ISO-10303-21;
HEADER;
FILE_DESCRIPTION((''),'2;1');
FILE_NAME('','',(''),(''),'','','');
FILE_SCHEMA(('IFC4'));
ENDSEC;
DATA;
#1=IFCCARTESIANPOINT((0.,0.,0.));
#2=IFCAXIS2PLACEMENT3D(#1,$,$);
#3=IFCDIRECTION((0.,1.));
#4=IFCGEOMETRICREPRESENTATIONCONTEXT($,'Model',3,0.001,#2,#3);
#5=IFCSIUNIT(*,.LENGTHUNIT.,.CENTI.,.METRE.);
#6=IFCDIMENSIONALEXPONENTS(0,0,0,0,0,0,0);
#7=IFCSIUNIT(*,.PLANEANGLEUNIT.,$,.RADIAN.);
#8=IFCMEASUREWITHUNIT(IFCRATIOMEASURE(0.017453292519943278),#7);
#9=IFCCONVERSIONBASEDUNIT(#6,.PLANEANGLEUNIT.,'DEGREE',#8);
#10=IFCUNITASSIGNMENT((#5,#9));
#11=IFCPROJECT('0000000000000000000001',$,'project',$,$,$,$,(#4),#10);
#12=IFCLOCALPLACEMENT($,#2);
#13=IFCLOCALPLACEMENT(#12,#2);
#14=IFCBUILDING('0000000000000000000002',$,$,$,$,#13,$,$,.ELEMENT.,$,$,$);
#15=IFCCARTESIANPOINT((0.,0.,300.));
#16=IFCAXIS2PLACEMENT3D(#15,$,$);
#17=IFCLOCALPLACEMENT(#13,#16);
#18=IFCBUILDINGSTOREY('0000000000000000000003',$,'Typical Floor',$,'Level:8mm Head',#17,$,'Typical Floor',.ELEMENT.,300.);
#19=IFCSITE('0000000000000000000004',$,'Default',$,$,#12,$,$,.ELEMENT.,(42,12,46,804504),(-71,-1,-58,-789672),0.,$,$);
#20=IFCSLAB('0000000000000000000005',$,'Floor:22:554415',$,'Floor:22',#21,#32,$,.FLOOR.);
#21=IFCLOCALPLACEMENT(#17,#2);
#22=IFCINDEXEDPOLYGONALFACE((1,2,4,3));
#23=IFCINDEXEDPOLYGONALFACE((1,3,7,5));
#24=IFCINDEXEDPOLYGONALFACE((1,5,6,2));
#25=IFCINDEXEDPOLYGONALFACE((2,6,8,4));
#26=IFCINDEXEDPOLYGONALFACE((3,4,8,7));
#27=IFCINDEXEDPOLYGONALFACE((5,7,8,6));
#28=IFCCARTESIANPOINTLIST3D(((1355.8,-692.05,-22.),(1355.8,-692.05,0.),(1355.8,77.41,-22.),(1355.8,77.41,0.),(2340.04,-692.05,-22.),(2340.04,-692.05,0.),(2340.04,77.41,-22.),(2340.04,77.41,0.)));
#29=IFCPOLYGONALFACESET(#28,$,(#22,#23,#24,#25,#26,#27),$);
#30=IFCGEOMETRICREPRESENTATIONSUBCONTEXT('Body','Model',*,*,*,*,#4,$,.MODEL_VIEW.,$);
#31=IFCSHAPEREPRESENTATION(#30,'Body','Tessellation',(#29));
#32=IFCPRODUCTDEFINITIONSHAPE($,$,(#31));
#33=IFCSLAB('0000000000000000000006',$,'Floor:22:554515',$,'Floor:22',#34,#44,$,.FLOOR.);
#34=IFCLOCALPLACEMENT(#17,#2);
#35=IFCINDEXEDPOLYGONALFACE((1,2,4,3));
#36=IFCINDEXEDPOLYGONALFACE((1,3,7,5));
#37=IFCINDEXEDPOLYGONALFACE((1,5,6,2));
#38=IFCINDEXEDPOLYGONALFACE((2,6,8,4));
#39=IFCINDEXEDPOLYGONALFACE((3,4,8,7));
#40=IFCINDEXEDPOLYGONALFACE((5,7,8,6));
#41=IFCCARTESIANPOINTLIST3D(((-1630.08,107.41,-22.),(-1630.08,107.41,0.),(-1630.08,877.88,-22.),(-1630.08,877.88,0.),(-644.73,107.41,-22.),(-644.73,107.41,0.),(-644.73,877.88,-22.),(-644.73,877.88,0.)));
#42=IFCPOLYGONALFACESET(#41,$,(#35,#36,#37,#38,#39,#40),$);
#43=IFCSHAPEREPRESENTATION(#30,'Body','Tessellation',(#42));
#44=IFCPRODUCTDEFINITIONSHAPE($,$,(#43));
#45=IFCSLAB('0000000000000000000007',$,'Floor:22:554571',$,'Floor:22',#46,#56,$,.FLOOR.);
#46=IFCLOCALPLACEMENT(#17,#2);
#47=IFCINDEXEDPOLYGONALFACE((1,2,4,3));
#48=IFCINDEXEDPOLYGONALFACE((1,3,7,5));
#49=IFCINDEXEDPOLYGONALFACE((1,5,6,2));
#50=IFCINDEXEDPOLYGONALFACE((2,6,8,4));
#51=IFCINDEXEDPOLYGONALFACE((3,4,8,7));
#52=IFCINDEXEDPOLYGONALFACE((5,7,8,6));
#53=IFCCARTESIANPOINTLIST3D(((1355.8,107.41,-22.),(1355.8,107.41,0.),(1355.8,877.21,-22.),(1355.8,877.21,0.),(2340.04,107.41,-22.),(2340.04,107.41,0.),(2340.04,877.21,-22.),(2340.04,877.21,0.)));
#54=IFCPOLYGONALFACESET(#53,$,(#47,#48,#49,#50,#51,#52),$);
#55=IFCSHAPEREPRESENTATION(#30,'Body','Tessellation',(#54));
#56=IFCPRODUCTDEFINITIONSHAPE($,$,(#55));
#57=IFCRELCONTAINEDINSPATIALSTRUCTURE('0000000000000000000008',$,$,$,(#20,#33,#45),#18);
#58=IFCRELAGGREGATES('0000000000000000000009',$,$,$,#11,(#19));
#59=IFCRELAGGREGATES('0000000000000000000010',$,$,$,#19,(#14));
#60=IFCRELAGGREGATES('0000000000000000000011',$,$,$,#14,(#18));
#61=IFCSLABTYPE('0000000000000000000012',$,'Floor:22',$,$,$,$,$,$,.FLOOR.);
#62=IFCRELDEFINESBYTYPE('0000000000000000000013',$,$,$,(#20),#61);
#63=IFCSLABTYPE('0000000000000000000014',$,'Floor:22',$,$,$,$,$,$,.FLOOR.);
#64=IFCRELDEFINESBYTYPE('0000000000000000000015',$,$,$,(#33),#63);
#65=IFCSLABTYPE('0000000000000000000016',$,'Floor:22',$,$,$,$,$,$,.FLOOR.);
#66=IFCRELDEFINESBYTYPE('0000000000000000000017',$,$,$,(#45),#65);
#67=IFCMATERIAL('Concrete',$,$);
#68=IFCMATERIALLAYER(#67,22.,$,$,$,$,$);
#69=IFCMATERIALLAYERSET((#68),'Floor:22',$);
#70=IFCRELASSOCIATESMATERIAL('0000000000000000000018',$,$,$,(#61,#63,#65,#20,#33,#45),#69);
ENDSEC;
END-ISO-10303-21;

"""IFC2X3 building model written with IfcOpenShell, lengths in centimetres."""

from ifc_helpers import new_model, entity, si_unit, converted_unit, direction, frame, frame_2d, origin, place, context, subcontext, project, spatial, rectangle, extrude, material, layer, layer_set, layer_usage, type_object, element, save


model = new_model("IFC2X3")

# Units and contexts
model_context = context("Model", 3, precision=0.001, world=origin(), true_north=direction((0.0, 1.0)))
body_context = subcontext(model_context, "Body", "Model", "MODEL_VIEW")
ifc_project = project(units=[si_unit("LENGTHUNIT", "METRE", prefix="CENTI"), converted_unit("PLANEANGLEUNIT", "DEGREE", entity("IfcRatioMeasure", 0.017453292519943278), si_unit("PLANEANGLEUNIT", "RADIAN"), dimensions=[0, 0, 0, 0, 0, 0, 0])], contexts=[model_context])

# Site, building, storey
site_placement = place(None, origin())
site = spatial("IfcSite", under=ifc_project, at=site_placement, Name="Default", CompositionType="ELEMENT", RefLatitude=(42, 12, 46, 804504), RefLongitude=(-71, -1, -58, -789672), RefElevation=0.0)
building_placement = place(site_placement, origin())
building = spatial("IfcBuilding", under=site, at=building_placement, CompositionType="ELEMENT")
storey_placement = place(building_placement, frame((0.0, 0.0, 300.0)))
storey = spatial("IfcBuildingStorey", under=building, at=storey_placement, Name="Typical Floor", ObjectType="Level:8mm Head", LongName="Typical Floor", CompositionType="ELEMENT", Elevation=300.0)

# Shared definitions
ifc_material = material(Name="Concrete")

# Slabs
ifc_layer = layer(ifc_material, 22.0)
ifc_layer_set = layer_set([ifc_layer], Name="Floor:22")
ifc_layer_usage_1 = layer_usage(ifc_layer_set, "AXIS3", "POSITIVE", 0.0)
slab_type_1 = type_object("IfcSlabType", Name="Floor:22", PredefinedType="FLOOR", material=ifc_layer_set)
slab_1_placement = place(storey_placement, origin())
element("IfcSlab", 1, at=slab_1_placement, inside=storey, type_object=slab_type_1, material=ifc_layer_usage_1, Name="Floor:22:554415", ObjectType="Floor:22", PredefinedType="FLOOR", context=body_context, shape_type="SweptSolid", body=[
    extrude(rectangle(XDim=769.46, YDim=984.24, at=frame_2d((0.0, 0.0), x_axis=(1.0, 0.0))), frame((1847.92, -307.32, 0.0), z_axis=(0.0, 0.0, -1.0), x_axis=(0.0, 1.0, 0.0)), (0.0, 0.0, 1.0), 22.0),
])
ifc_layer_usage_2 = layer_usage(ifc_layer_set, "AXIS3", "POSITIVE", 0.0)
slab_type_2 = type_object("IfcSlabType", Name="Floor:22", PredefinedType="FLOOR", material=ifc_layer_set)
slab_2_placement = place(storey_placement, origin())
element("IfcSlab", 2, at=slab_2_placement, inside=storey, type_object=slab_type_2, material=ifc_layer_usage_2, Name="Floor:22:554515", ObjectType="Floor:22", PredefinedType="FLOOR", context=body_context, shape_type="SweptSolid", body=[
    extrude(rectangle(XDim=770.47, YDim=985.35, at=frame_2d((0.0, 0.0), x_axis=(1.0, 0.0))), frame((-1137.41, 492.64, 0.0), z_axis=(0.0, 0.0, -1.0), x_axis=(0.0, 1.0, 0.0)), (0.0, 0.0, 1.0), 22.0),
])
ifc_layer_usage_3 = layer_usage(ifc_layer_set, "AXIS3", "POSITIVE", 0.0)
slab_type_3 = type_object("IfcSlabType", Name="Floor:22", PredefinedType="FLOOR", material=ifc_layer_set)
slab_3_placement = place(storey_placement, origin())
element("IfcSlab", 3, at=slab_3_placement, inside=storey, type_object=slab_type_3, material=ifc_layer_usage_3, Name="Floor:22:554571", ObjectType="Floor:22", PredefinedType="FLOOR", context=body_context, shape_type="SweptSolid", body=[
    extrude(rectangle(XDim=769.8, YDim=984.24, at=frame_2d((0.0, 0.0), x_axis=(1.0, 0.0))), frame((1847.92, 492.31, 0.0), z_axis=(0.0, 0.0, -1.0), x_axis=(0.0, 1.0, 0.0)), (0.0, 0.0, 1.0), 22.0),
])

save(model, "model.ifc")
